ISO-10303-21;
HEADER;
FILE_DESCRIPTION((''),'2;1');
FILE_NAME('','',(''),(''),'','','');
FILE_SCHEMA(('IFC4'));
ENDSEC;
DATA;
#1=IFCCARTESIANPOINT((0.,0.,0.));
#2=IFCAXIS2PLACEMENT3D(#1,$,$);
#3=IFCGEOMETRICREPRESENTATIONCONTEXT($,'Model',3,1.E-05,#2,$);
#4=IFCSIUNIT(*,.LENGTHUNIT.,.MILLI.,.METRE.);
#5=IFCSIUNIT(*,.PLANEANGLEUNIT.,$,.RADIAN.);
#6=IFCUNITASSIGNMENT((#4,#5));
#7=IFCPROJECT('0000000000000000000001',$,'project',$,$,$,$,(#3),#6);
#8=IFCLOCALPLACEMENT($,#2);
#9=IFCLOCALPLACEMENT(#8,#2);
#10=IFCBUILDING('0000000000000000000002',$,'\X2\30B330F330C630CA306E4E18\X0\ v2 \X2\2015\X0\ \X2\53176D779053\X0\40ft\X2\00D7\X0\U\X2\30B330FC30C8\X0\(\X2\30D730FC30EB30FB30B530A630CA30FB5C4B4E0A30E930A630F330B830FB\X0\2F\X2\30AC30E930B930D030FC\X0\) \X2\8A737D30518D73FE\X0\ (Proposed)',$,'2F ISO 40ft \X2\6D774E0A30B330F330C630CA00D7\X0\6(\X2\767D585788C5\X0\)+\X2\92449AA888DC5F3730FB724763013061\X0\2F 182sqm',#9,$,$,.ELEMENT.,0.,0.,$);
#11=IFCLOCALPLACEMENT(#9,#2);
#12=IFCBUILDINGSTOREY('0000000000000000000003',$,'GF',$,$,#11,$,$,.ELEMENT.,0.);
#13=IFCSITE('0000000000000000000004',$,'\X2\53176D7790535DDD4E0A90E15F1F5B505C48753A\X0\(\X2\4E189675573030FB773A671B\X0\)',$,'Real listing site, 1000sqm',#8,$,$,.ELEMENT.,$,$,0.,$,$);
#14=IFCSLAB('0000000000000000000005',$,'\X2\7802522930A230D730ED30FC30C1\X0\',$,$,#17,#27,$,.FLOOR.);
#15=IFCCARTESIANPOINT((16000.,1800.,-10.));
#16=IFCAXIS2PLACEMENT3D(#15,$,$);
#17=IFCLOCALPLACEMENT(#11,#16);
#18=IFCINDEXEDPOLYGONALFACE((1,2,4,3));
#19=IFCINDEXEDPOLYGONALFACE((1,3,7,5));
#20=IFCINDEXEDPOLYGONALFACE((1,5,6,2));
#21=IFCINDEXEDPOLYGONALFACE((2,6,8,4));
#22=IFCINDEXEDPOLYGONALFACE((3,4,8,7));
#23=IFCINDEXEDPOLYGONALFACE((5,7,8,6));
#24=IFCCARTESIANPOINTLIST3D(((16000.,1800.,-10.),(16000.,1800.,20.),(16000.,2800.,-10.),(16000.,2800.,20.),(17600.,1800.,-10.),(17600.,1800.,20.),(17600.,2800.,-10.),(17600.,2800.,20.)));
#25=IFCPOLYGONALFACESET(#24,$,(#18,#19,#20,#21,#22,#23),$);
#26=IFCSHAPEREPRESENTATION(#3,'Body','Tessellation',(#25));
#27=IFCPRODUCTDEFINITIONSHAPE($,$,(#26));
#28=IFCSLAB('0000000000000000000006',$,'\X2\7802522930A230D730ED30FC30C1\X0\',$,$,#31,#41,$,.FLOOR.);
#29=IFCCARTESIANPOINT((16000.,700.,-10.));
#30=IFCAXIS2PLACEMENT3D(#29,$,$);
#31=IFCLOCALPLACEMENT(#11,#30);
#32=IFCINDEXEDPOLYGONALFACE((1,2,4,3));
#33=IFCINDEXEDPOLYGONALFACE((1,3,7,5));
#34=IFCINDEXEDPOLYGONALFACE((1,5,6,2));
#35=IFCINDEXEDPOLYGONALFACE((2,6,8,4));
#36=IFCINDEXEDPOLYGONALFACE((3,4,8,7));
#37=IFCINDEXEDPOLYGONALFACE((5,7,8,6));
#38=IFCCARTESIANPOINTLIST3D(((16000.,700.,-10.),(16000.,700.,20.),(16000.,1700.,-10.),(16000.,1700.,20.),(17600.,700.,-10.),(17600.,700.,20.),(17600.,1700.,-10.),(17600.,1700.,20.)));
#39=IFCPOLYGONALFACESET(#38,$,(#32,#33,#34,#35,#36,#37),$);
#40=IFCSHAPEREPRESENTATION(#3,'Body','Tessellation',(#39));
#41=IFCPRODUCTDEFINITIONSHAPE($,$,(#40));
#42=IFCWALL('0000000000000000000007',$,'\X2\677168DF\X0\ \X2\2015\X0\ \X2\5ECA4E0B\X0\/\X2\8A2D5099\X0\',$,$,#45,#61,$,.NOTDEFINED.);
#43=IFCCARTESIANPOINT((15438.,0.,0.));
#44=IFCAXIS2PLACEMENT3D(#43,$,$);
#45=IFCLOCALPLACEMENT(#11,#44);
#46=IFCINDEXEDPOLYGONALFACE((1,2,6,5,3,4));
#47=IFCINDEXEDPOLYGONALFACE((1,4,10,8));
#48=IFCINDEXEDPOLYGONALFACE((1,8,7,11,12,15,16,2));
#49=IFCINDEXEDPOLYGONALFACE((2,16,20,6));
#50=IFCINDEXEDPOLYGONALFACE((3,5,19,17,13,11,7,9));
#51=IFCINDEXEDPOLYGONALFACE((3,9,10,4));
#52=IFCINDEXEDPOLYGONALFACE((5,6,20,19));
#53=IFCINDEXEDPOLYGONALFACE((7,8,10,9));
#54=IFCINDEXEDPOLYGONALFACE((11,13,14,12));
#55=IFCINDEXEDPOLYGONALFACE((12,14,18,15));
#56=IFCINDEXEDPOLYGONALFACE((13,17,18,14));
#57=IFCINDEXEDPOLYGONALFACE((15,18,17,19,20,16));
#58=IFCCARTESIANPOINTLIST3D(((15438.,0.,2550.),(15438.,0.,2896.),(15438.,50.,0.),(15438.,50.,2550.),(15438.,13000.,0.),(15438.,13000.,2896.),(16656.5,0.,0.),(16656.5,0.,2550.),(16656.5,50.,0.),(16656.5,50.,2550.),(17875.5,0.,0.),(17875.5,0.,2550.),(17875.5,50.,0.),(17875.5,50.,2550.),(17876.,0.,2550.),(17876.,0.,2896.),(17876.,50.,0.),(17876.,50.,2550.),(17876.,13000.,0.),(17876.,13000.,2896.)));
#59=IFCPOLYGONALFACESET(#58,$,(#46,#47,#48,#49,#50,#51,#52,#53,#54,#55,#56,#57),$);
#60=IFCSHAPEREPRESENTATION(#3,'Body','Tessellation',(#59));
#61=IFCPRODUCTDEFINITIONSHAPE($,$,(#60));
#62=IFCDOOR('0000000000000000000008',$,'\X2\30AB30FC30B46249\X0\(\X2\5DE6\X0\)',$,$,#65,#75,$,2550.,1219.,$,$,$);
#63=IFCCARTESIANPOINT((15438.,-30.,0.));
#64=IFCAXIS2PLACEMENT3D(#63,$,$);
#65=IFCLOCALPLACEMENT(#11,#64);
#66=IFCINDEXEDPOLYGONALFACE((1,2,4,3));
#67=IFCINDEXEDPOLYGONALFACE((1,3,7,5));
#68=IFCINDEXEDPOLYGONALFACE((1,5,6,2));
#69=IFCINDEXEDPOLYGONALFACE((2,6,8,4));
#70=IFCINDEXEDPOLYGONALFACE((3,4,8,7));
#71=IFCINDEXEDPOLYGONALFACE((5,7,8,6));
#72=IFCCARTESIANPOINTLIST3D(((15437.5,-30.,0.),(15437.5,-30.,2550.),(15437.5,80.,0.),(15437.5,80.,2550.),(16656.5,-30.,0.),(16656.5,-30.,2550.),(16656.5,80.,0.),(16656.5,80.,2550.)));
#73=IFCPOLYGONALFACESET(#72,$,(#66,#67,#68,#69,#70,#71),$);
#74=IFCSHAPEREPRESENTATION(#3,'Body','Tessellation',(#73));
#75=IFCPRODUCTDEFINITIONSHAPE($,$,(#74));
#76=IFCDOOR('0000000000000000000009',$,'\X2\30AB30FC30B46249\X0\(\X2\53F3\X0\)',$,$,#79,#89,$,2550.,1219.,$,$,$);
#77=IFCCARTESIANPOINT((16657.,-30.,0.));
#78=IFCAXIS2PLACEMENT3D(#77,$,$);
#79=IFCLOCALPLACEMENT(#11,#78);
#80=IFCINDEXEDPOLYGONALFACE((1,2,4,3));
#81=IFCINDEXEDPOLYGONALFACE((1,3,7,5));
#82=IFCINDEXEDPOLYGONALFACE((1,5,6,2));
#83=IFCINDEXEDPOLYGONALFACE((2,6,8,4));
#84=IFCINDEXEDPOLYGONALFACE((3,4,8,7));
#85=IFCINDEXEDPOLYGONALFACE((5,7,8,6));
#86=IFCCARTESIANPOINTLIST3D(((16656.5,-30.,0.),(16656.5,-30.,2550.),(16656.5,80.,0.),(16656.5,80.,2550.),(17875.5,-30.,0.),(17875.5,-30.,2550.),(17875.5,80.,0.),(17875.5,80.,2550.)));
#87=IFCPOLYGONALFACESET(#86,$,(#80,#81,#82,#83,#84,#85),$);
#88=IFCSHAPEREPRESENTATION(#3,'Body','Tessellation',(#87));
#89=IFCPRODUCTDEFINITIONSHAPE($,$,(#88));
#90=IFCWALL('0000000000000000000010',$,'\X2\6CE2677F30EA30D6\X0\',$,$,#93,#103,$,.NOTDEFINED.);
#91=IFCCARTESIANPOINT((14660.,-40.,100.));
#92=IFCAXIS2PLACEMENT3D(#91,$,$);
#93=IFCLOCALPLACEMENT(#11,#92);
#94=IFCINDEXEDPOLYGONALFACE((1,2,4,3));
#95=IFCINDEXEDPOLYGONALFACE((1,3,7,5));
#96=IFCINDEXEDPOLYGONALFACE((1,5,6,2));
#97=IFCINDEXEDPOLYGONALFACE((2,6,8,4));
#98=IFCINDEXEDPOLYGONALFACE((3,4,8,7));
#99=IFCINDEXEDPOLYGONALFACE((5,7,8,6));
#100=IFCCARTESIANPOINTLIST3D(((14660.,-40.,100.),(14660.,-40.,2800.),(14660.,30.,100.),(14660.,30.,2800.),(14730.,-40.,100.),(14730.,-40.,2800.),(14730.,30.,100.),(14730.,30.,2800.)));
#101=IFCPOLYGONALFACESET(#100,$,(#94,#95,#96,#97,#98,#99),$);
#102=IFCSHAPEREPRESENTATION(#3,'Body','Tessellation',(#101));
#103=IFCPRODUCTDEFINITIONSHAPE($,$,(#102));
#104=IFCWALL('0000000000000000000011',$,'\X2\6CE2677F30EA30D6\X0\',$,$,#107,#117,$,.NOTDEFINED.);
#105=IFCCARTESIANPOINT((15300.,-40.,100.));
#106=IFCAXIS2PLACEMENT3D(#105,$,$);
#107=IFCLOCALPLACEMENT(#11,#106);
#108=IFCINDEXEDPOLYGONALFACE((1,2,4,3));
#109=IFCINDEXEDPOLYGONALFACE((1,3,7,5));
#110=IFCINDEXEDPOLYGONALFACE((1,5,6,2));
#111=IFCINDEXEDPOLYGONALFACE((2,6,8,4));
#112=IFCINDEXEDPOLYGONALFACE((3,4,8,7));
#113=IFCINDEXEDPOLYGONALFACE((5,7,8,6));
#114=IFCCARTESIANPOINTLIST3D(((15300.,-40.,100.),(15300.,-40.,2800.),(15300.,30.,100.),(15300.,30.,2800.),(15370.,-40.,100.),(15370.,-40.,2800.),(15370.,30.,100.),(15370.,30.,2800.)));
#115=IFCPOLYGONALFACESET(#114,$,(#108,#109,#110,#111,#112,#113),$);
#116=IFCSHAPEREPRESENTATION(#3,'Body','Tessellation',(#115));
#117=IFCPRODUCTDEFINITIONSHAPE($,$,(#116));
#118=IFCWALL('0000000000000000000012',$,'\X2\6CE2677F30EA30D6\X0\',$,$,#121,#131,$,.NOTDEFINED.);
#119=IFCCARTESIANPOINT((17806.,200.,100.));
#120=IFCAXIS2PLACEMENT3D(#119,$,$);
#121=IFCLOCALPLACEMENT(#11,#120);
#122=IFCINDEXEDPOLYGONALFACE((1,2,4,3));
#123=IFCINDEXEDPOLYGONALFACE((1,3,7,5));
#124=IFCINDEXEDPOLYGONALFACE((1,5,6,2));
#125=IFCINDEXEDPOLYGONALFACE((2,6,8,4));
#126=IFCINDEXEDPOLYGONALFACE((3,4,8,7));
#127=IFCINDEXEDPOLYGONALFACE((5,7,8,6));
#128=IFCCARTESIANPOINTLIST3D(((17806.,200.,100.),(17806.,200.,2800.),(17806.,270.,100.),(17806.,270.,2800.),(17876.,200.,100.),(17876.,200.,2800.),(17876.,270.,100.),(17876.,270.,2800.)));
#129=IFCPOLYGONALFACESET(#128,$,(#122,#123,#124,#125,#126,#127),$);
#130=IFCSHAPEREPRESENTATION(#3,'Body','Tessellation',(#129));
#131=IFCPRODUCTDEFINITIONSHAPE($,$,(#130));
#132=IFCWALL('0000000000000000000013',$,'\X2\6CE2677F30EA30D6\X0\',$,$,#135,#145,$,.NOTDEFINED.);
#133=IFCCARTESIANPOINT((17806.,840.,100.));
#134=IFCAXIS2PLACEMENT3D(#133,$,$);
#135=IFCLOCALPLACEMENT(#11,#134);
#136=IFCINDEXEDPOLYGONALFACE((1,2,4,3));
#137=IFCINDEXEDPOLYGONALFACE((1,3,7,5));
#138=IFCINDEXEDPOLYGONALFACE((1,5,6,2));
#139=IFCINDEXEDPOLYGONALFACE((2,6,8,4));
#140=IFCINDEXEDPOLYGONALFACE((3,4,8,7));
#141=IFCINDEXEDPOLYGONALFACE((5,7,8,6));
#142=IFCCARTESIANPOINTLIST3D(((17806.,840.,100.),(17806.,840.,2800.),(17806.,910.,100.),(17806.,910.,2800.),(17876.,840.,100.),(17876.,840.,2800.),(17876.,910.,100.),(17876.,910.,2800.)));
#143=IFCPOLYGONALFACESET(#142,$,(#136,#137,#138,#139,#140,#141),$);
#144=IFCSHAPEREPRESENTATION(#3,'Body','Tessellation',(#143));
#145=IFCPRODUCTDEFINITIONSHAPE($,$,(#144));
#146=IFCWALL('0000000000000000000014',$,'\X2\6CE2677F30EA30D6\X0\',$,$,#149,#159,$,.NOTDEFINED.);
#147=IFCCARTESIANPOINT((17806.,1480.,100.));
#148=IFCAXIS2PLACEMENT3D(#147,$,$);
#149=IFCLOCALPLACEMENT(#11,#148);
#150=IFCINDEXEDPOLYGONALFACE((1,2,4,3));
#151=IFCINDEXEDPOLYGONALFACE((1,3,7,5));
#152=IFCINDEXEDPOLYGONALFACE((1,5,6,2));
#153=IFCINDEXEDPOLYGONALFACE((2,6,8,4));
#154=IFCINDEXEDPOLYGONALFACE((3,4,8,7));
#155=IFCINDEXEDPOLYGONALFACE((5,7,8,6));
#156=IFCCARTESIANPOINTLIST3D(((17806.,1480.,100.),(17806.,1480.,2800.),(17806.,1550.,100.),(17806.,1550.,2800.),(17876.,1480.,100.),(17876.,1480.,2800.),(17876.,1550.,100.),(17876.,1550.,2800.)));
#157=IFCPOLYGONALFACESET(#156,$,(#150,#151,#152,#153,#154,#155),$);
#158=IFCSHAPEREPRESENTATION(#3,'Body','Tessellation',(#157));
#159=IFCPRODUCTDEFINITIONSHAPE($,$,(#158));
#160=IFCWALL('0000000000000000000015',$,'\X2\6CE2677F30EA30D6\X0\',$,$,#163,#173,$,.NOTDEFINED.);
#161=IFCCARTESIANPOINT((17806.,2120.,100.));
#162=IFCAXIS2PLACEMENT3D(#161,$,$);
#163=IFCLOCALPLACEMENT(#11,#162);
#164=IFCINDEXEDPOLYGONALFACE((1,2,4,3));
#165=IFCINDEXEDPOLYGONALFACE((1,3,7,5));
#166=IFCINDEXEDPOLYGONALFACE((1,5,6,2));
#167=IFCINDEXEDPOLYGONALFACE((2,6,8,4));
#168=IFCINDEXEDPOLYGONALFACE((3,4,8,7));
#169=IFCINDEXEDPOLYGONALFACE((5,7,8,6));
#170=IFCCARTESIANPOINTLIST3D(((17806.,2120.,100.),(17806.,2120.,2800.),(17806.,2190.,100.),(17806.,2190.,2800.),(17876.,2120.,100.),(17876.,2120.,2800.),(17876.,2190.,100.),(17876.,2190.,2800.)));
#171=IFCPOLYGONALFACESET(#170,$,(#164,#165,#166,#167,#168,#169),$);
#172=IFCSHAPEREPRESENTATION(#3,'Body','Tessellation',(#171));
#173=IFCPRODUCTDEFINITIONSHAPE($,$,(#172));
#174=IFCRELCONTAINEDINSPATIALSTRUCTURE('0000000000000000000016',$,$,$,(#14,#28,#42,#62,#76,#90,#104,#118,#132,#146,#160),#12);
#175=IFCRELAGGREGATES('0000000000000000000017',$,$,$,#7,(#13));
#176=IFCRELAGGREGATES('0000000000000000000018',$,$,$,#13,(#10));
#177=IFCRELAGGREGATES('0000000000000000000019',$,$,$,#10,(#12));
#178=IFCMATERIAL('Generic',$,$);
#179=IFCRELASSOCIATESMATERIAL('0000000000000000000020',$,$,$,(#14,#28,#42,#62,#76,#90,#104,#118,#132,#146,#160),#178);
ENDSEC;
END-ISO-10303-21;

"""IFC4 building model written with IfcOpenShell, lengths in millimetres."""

from ifc_helpers import new_model, si_unit, frame, frame_2d, origin, place, context, project, spatial, rectangle, extrude, material, element, fill, save


model = new_model("IFC4")

# Units and contexts
model_context = context("Model", 3, precision=1e-05, world=origin())
ifc_project = project(units=[si_unit("LENGTHUNIT", "METRE", prefix="MILLI"), si_unit("PLANEANGLEUNIT", "RADIAN")], contexts=[model_context])

# Site, building, storey
site_placement = place(None, origin())
site = spatial("IfcSite", under=ifc_project, at=site_placement, Name="北海道川上郡弟子屈町(丘陵地・眺望)", ObjectType="Real listing site, 1000sqm", CompositionType="ELEMENT", RefElevation=0.0)
building_placement = place(site_placement, origin())
building = spatial("IfcBuilding", under=site, at=building_placement, Name="コンテナの丘 v2 ― 北海道40ft×Uコート(プール・サウナ・屋上ラウンジ・2Fガラスバー) 詳細再現 (Proposed)", ObjectType="2F ISO 40ft 海上コンテナ×6(白塗装)+鉄骨補強・片持ち2F 182sqm", CompositionType="ELEMENT", ElevationOfRefHeight=0.0, ElevationOfTerrain=0.0)
storey_placement = place(building_placement, origin())
storey = spatial("IfcBuildingStorey", under=building, at=storey_placement, Name="GF", CompositionType="ELEMENT", Elevation=0.0)

# Slabs
ifc_material = material(Name="Generic")
slab_1_placement = place(storey_placement, frame((16000.0, 1800.0, -10.0)))
element("IfcSlab", 1, at=slab_1_placement, inside=storey, material=ifc_material, Name="砂利アプローチ", PredefinedType="FLOOR", context=model_context, shape_type="SweptSolid", body=[
    extrude(rectangle(XDim=1600.0, YDim=1000.0, at=frame_2d((800.0, 500.0))), frame((16000.0, 1800.0, -10.0)), (0.0, 0.0, 1.0), 30.0),
])
slab_2_placement = place(storey_placement, frame((16000.0, 700.0, -10.0)))
element("IfcSlab", 2, at=slab_2_placement, inside=storey, material=ifc_material, Name="砂利アプローチ", PredefinedType="FLOOR", context=model_context, shape_type="SweptSolid", body=[
    extrude(rectangle(XDim=1600.0, YDim=1000.0, at=frame_2d((800.0, 500.0))), frame((16000.0, 700.0, -10.0)), (0.0, 0.0, 1.0), 30.0),
])

# Wall, openings, doors
wall_1_placement = place(storey_placement, frame((15438.0, 0.0, 0.0)))
wall_1 = element("IfcWall", 3, at=wall_1_placement, inside=storey, material=ifc_material, Name="東棟 ― 廊下/設備", PredefinedType="NOTDEFINED", context=model_context, shape_type="SweptSolid", body=[
    extrude(rectangle(XDim=2438.0, YDim=13000.0, at=frame_2d((1219.0, 6500.0))), frame((15438.0, 0.0, 0.0)), (0.0, 0.0, 1.0), 2896.0),
])
opening_1_placement = place(storey_placement, frame((15438.0, -30.0, 0.0)))
opening_1 = element("IfcOpeningElement", 4, at=opening_1_placement, cuts=wall_1, PredefinedType="NOTDEFINED", context=model_context, shape_type="SweptSolid", body=[
    extrude(rectangle(XDim=1219.0, YDim=110.0, at=frame_2d((609.0, 55.0))), frame((15438.0, -30.0, 0.0)), (0.0, 0.0, 1.0), 2550.0),
])
opening_2_placement = place(storey_placement, frame((16657.0, -30.0, 0.0)))
opening_2 = element("IfcOpeningElement", 5, at=opening_2_placement, cuts=wall_1, PredefinedType="NOTDEFINED", context=model_context, shape_type="SweptSolid", body=[
    extrude(rectangle(XDim=1219.0, YDim=110.0, at=frame_2d((609.0, 55.0))), frame((16657.0, -30.0, 0.0)), (0.0, 0.0, 1.0), 2550.0),
])
door_1_placement = place(storey_placement, frame((15438.0, -30.0, 0.0)))
door_1 = element("IfcDoor", 6, at=door_1_placement, inside=storey, material=ifc_material, Name="カーゴ扉(左)", OverallHeight=2550.0, OverallWidth=1219.0, context=model_context, shape_type="SweptSolid", body=[
    extrude(rectangle(XDim=1219.0, YDim=110.0, at=frame_2d((609.0, 55.0))), frame((15438.0, -30.0, 0.0)), (0.0, 0.0, 1.0), 2550.0),
])
fill(opening_1, door_1)
door_2_placement = place(storey_placement, frame((16657.0, -30.0, 0.0)))
door_2 = element("IfcDoor", 7, at=door_2_placement, inside=storey, material=ifc_material, Name="カーゴ扉(右)", OverallHeight=2550.0, OverallWidth=1219.0, context=model_context, shape_type="SweptSolid", body=[
    extrude(rectangle(XDim=1219.0, YDim=110.0, at=frame_2d((609.0, 55.0))), frame((16657.0, -30.0, 0.0)), (0.0, 0.0, 1.0), 2550.0),
])
fill(opening_2, door_2)

# Walls
wall_2_placement = place(storey_placement, frame((14660.0, -40.0, 100.0)))
element("IfcWall", 8, at=wall_2_placement, inside=storey, material=ifc_material, Name="波板リブ", PredefinedType="NOTDEFINED", context=model_context, shape_type="SweptSolid", body=[
    extrude(rectangle(XDim=70.0, YDim=70.0, at=frame_2d((35.0, 35.0))), frame((14660.0, -40.0, 100.0)), (0.0, 0.0, 1.0), 2700.0),
])
wall_3_placement = place(storey_placement, frame((15300.0, -40.0, 100.0)))
element("IfcWall", 9, at=wall_3_placement, inside=storey, material=ifc_material, Name="波板リブ", PredefinedType="NOTDEFINED", context=model_context, shape_type="SweptSolid", body=[
    extrude(rectangle(XDim=70.0, YDim=70.0, at=frame_2d((35.0, 35.0))), frame((15300.0, -40.0, 100.0)), (0.0, 0.0, 1.0), 2700.0),
])
wall_4_placement = place(storey_placement, frame((17806.0, 200.0, 100.0)))
element("IfcWall", 10, at=wall_4_placement, inside=storey, material=ifc_material, Name="波板リブ", PredefinedType="NOTDEFINED", context=model_context, shape_type="SweptSolid", body=[
    extrude(rectangle(XDim=70.0, YDim=70.0, at=frame_2d((35.0, 35.0))), frame((17806.0, 200.0, 100.0)), (0.0, 0.0, 1.0), 2700.0),
])
wall_5_placement = place(storey_placement, frame((17806.0, 840.0, 100.0)))
element("IfcWall", 11, at=wall_5_placement, inside=storey, material=ifc_material, Name="波板リブ", PredefinedType="NOTDEFINED", context=model_context, shape_type="SweptSolid", body=[
    extrude(rectangle(XDim=70.0, YDim=70.0, at=frame_2d((35.0, 35.0))), frame((17806.0, 840.0, 100.0)), (0.0, 0.0, 1.0), 2700.0),
])
wall_6_placement = place(storey_placement, frame((17806.0, 1480.0, 100.0)))
element("IfcWall", 12, at=wall_6_placement, inside=storey, material=ifc_material, Name="波板リブ", PredefinedType="NOTDEFINED", context=model_context, shape_type="SweptSolid", body=[
    extrude(rectangle(XDim=70.0, YDim=70.0, at=frame_2d((35.0, 35.0))), frame((17806.0, 1480.0, 100.0)), (0.0, 0.0, 1.0), 2700.0),
])
wall_7_placement = place(storey_placement, frame((17806.0, 2120.0, 100.0)))
element("IfcWall", 13, at=wall_7_placement, inside=storey, material=ifc_material, Name="波板リブ", PredefinedType="NOTDEFINED", context=model_context, shape_type="SweptSolid", body=[
    extrude(rectangle(XDim=70.0, YDim=70.0, at=frame_2d((35.0, 35.0))), frame((17806.0, 2120.0, 100.0)), (0.0, 0.0, 1.0), 2700.0),
])

save(model, "model.ifc")
